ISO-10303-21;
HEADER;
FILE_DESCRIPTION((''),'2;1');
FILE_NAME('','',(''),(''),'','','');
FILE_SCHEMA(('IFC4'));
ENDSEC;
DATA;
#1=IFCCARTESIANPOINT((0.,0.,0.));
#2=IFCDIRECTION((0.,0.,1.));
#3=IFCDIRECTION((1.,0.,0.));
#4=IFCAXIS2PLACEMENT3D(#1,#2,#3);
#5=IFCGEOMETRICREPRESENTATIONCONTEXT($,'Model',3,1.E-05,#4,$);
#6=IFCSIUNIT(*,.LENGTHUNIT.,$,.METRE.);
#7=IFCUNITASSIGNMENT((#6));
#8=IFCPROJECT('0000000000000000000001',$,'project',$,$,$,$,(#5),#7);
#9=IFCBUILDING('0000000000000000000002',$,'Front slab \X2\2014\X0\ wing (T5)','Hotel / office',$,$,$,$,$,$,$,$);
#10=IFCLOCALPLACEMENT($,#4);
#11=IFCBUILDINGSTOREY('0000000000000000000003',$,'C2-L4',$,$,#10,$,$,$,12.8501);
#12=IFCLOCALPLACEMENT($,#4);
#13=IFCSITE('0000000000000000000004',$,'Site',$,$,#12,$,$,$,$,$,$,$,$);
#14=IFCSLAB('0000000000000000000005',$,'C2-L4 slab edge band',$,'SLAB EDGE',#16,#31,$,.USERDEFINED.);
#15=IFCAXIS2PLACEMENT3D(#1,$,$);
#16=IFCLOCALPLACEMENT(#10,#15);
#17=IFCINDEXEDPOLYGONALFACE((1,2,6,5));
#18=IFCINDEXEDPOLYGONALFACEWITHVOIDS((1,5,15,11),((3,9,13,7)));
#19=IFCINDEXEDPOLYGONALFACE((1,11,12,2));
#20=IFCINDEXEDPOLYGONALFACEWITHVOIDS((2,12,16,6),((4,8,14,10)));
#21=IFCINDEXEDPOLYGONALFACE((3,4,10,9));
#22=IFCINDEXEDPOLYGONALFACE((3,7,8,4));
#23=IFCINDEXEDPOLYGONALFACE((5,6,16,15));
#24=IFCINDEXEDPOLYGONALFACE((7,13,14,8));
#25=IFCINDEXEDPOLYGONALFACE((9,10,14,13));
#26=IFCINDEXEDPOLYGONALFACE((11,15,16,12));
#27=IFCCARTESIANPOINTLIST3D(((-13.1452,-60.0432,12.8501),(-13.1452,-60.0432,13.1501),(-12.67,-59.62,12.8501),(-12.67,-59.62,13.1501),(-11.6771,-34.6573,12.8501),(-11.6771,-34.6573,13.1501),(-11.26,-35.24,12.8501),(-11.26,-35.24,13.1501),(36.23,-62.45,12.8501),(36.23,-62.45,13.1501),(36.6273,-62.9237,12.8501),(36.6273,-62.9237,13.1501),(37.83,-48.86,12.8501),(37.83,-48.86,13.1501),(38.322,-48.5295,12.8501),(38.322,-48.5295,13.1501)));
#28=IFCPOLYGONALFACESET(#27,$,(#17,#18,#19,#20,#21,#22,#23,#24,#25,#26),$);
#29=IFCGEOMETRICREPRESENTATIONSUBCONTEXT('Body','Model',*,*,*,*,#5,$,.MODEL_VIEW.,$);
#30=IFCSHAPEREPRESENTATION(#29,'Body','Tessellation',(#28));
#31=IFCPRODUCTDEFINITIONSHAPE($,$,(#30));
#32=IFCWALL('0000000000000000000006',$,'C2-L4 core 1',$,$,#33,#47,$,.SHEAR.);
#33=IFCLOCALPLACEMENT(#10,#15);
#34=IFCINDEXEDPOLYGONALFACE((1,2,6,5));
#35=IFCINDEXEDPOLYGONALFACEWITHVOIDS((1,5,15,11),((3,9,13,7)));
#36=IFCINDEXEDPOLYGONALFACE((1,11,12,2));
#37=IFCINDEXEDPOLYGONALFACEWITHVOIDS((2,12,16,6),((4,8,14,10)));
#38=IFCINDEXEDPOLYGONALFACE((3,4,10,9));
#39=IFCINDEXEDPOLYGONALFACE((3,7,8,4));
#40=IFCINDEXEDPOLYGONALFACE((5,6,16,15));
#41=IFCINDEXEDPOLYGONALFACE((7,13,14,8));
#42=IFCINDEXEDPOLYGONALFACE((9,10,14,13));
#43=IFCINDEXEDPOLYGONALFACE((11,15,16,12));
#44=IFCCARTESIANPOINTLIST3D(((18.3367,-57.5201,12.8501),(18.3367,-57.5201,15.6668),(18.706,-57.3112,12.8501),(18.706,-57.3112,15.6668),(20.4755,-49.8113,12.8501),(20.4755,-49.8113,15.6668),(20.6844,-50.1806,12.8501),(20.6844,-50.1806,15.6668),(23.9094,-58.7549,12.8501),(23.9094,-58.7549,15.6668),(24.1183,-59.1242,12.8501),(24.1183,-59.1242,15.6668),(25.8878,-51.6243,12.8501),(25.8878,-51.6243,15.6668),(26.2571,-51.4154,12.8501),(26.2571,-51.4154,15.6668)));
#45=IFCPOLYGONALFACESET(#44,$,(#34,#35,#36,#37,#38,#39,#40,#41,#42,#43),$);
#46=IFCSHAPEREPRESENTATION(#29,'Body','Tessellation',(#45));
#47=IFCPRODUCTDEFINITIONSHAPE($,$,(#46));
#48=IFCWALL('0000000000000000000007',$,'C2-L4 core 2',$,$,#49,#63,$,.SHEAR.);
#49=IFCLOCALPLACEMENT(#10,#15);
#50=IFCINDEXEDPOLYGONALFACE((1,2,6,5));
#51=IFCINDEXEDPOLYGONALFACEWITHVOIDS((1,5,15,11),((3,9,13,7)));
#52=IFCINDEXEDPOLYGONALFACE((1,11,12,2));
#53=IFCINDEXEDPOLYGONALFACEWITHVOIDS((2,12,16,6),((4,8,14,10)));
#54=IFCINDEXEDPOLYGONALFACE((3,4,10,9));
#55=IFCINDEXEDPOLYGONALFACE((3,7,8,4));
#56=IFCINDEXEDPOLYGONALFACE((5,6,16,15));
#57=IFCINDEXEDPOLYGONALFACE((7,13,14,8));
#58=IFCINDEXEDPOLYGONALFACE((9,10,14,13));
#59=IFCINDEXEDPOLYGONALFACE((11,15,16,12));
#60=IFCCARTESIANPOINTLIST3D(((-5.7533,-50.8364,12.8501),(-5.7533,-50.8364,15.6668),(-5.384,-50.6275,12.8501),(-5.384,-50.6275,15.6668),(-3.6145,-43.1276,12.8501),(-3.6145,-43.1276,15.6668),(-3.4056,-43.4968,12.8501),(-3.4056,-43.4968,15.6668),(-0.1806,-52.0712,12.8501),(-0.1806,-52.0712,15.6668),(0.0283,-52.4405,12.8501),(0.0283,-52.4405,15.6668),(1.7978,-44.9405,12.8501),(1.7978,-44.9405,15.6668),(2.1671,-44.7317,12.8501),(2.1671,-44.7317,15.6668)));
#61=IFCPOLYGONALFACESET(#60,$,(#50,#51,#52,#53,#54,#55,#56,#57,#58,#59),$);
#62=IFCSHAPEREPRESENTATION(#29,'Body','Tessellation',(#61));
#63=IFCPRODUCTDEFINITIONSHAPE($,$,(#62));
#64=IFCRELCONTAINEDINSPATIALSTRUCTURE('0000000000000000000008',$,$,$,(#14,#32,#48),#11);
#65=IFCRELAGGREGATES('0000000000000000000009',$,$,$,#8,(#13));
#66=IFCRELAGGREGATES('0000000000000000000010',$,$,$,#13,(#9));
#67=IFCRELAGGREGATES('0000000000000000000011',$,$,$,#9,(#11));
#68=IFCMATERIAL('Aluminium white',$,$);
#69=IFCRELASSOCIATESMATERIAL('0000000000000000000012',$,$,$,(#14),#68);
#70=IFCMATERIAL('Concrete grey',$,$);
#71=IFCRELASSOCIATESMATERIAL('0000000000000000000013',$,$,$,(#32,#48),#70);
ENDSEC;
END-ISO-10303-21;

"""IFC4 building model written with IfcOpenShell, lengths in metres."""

from ifc_helpers import new_model, si_unit, frame, origin_with_axes, place, context, subcontext, project, spatial, polyline, outline, extrude, material, element, save


model = new_model("IFC4")

# Units and contexts
model_context = context("Model", 3, precision=1e-05, world=origin_with_axes())
body_context = subcontext(model_context, "Body", "Model", "MODEL_VIEW")
ifc_project = project(units=[si_unit("LENGTHUNIT", "METRE")], contexts=[model_context])

# Site, building, storey
site_placement = place(None, origin_with_axes())
site = spatial("IfcSite", under=ifc_project, at=site_placement, Name="Site")
building = spatial("IfcBuilding", under=site, Name="Front slab — wing (T5)", Description="Hotel / office")
storey_placement = place(None, origin_with_axes())
storey = spatial("IfcBuildingStorey", under=building, at=storey_placement, Name="C2-L4", Elevation=12.8501)

# Shared definitions
ifc_material_1 = material(Name="Aluminium white")

# Slab
slab_placement = place(storey_placement, origin_with_axes())
element("IfcSlab", 1, at=slab_placement, inside=storey, material=ifc_material_1, Name="C2-L4 slab edge band", ObjectType="SLAB EDGE", PredefinedType="USERDEFINED", context=body_context, shape_type="SweptSolid", body=[
    extrude(outline(polyline([(-11.6771, -34.6573), (-13.1452, -60.0432), (36.6273, -62.9237), (38.322, -48.5295), (-11.6771, -34.6573)]), holes=[polyline([(-11.26, -35.24), (-12.67, -59.62), (36.23, -62.45), (37.83, -48.86), (-11.26, -35.24)])]), frame((0.0, 0.0, 12.8501), z_axis=(0.0, 0.0, 1.0), x_axis=(1.0, 0.0, 0.0)), (0.0, 0.0, 1.0), 0.3),
])

# Walls
ifc_material_2 = material(Name="Concrete grey")
wall_1_placement = place(storey_placement, origin_with_axes())
element("IfcWall", 2, at=wall_1_placement, inside=storey, material=ifc_material_2, Name="C2-L4 core 1", PredefinedType="SHEAR", context=body_context, shape_type="SweptSolid", body=[
    extrude(outline(polyline([(26.2571, -51.4154), (20.4755, -49.8113), (18.3367, -57.5201), (24.1183, -59.1242), (26.2571, -51.4154)]), holes=[polyline([(25.8878, -51.6243), (20.6844, -50.1806), (18.706, -57.3112), (23.9094, -58.7549), (25.8878, -51.6243)])]), frame((0.0, 0.0, 12.8501), z_axis=(0.0, 0.0, 1.0), x_axis=(1.0, 0.0, 0.0)), (0.0, 0.0, 1.0), 2.8167),
])
wall_2_placement = place(storey_placement, origin_with_axes())
element("IfcWall", 3, at=wall_2_placement, inside=storey, material=ifc_material_2, Name="C2-L4 core 2", PredefinedType="SHEAR", context=body_context, shape_type="SweptSolid", body=[
    extrude(outline(polyline([(2.1671, -44.7317), (-3.6145, -43.1276), (-5.7533, -50.8364), (0.0283, -52.4405), (2.1671, -44.7317)]), holes=[polyline([(1.7978, -44.9405), (-3.4056, -43.4968), (-5.384, -50.6275), (-0.1806, -52.0712), (1.7978, -44.9405)])]), frame((0.0, 0.0, 12.8501), z_axis=(0.0, 0.0, 1.0), x_axis=(1.0, 0.0, 0.0)), (0.0, 0.0, 1.0), 2.8167),
])

save(model, "model.ifc")
